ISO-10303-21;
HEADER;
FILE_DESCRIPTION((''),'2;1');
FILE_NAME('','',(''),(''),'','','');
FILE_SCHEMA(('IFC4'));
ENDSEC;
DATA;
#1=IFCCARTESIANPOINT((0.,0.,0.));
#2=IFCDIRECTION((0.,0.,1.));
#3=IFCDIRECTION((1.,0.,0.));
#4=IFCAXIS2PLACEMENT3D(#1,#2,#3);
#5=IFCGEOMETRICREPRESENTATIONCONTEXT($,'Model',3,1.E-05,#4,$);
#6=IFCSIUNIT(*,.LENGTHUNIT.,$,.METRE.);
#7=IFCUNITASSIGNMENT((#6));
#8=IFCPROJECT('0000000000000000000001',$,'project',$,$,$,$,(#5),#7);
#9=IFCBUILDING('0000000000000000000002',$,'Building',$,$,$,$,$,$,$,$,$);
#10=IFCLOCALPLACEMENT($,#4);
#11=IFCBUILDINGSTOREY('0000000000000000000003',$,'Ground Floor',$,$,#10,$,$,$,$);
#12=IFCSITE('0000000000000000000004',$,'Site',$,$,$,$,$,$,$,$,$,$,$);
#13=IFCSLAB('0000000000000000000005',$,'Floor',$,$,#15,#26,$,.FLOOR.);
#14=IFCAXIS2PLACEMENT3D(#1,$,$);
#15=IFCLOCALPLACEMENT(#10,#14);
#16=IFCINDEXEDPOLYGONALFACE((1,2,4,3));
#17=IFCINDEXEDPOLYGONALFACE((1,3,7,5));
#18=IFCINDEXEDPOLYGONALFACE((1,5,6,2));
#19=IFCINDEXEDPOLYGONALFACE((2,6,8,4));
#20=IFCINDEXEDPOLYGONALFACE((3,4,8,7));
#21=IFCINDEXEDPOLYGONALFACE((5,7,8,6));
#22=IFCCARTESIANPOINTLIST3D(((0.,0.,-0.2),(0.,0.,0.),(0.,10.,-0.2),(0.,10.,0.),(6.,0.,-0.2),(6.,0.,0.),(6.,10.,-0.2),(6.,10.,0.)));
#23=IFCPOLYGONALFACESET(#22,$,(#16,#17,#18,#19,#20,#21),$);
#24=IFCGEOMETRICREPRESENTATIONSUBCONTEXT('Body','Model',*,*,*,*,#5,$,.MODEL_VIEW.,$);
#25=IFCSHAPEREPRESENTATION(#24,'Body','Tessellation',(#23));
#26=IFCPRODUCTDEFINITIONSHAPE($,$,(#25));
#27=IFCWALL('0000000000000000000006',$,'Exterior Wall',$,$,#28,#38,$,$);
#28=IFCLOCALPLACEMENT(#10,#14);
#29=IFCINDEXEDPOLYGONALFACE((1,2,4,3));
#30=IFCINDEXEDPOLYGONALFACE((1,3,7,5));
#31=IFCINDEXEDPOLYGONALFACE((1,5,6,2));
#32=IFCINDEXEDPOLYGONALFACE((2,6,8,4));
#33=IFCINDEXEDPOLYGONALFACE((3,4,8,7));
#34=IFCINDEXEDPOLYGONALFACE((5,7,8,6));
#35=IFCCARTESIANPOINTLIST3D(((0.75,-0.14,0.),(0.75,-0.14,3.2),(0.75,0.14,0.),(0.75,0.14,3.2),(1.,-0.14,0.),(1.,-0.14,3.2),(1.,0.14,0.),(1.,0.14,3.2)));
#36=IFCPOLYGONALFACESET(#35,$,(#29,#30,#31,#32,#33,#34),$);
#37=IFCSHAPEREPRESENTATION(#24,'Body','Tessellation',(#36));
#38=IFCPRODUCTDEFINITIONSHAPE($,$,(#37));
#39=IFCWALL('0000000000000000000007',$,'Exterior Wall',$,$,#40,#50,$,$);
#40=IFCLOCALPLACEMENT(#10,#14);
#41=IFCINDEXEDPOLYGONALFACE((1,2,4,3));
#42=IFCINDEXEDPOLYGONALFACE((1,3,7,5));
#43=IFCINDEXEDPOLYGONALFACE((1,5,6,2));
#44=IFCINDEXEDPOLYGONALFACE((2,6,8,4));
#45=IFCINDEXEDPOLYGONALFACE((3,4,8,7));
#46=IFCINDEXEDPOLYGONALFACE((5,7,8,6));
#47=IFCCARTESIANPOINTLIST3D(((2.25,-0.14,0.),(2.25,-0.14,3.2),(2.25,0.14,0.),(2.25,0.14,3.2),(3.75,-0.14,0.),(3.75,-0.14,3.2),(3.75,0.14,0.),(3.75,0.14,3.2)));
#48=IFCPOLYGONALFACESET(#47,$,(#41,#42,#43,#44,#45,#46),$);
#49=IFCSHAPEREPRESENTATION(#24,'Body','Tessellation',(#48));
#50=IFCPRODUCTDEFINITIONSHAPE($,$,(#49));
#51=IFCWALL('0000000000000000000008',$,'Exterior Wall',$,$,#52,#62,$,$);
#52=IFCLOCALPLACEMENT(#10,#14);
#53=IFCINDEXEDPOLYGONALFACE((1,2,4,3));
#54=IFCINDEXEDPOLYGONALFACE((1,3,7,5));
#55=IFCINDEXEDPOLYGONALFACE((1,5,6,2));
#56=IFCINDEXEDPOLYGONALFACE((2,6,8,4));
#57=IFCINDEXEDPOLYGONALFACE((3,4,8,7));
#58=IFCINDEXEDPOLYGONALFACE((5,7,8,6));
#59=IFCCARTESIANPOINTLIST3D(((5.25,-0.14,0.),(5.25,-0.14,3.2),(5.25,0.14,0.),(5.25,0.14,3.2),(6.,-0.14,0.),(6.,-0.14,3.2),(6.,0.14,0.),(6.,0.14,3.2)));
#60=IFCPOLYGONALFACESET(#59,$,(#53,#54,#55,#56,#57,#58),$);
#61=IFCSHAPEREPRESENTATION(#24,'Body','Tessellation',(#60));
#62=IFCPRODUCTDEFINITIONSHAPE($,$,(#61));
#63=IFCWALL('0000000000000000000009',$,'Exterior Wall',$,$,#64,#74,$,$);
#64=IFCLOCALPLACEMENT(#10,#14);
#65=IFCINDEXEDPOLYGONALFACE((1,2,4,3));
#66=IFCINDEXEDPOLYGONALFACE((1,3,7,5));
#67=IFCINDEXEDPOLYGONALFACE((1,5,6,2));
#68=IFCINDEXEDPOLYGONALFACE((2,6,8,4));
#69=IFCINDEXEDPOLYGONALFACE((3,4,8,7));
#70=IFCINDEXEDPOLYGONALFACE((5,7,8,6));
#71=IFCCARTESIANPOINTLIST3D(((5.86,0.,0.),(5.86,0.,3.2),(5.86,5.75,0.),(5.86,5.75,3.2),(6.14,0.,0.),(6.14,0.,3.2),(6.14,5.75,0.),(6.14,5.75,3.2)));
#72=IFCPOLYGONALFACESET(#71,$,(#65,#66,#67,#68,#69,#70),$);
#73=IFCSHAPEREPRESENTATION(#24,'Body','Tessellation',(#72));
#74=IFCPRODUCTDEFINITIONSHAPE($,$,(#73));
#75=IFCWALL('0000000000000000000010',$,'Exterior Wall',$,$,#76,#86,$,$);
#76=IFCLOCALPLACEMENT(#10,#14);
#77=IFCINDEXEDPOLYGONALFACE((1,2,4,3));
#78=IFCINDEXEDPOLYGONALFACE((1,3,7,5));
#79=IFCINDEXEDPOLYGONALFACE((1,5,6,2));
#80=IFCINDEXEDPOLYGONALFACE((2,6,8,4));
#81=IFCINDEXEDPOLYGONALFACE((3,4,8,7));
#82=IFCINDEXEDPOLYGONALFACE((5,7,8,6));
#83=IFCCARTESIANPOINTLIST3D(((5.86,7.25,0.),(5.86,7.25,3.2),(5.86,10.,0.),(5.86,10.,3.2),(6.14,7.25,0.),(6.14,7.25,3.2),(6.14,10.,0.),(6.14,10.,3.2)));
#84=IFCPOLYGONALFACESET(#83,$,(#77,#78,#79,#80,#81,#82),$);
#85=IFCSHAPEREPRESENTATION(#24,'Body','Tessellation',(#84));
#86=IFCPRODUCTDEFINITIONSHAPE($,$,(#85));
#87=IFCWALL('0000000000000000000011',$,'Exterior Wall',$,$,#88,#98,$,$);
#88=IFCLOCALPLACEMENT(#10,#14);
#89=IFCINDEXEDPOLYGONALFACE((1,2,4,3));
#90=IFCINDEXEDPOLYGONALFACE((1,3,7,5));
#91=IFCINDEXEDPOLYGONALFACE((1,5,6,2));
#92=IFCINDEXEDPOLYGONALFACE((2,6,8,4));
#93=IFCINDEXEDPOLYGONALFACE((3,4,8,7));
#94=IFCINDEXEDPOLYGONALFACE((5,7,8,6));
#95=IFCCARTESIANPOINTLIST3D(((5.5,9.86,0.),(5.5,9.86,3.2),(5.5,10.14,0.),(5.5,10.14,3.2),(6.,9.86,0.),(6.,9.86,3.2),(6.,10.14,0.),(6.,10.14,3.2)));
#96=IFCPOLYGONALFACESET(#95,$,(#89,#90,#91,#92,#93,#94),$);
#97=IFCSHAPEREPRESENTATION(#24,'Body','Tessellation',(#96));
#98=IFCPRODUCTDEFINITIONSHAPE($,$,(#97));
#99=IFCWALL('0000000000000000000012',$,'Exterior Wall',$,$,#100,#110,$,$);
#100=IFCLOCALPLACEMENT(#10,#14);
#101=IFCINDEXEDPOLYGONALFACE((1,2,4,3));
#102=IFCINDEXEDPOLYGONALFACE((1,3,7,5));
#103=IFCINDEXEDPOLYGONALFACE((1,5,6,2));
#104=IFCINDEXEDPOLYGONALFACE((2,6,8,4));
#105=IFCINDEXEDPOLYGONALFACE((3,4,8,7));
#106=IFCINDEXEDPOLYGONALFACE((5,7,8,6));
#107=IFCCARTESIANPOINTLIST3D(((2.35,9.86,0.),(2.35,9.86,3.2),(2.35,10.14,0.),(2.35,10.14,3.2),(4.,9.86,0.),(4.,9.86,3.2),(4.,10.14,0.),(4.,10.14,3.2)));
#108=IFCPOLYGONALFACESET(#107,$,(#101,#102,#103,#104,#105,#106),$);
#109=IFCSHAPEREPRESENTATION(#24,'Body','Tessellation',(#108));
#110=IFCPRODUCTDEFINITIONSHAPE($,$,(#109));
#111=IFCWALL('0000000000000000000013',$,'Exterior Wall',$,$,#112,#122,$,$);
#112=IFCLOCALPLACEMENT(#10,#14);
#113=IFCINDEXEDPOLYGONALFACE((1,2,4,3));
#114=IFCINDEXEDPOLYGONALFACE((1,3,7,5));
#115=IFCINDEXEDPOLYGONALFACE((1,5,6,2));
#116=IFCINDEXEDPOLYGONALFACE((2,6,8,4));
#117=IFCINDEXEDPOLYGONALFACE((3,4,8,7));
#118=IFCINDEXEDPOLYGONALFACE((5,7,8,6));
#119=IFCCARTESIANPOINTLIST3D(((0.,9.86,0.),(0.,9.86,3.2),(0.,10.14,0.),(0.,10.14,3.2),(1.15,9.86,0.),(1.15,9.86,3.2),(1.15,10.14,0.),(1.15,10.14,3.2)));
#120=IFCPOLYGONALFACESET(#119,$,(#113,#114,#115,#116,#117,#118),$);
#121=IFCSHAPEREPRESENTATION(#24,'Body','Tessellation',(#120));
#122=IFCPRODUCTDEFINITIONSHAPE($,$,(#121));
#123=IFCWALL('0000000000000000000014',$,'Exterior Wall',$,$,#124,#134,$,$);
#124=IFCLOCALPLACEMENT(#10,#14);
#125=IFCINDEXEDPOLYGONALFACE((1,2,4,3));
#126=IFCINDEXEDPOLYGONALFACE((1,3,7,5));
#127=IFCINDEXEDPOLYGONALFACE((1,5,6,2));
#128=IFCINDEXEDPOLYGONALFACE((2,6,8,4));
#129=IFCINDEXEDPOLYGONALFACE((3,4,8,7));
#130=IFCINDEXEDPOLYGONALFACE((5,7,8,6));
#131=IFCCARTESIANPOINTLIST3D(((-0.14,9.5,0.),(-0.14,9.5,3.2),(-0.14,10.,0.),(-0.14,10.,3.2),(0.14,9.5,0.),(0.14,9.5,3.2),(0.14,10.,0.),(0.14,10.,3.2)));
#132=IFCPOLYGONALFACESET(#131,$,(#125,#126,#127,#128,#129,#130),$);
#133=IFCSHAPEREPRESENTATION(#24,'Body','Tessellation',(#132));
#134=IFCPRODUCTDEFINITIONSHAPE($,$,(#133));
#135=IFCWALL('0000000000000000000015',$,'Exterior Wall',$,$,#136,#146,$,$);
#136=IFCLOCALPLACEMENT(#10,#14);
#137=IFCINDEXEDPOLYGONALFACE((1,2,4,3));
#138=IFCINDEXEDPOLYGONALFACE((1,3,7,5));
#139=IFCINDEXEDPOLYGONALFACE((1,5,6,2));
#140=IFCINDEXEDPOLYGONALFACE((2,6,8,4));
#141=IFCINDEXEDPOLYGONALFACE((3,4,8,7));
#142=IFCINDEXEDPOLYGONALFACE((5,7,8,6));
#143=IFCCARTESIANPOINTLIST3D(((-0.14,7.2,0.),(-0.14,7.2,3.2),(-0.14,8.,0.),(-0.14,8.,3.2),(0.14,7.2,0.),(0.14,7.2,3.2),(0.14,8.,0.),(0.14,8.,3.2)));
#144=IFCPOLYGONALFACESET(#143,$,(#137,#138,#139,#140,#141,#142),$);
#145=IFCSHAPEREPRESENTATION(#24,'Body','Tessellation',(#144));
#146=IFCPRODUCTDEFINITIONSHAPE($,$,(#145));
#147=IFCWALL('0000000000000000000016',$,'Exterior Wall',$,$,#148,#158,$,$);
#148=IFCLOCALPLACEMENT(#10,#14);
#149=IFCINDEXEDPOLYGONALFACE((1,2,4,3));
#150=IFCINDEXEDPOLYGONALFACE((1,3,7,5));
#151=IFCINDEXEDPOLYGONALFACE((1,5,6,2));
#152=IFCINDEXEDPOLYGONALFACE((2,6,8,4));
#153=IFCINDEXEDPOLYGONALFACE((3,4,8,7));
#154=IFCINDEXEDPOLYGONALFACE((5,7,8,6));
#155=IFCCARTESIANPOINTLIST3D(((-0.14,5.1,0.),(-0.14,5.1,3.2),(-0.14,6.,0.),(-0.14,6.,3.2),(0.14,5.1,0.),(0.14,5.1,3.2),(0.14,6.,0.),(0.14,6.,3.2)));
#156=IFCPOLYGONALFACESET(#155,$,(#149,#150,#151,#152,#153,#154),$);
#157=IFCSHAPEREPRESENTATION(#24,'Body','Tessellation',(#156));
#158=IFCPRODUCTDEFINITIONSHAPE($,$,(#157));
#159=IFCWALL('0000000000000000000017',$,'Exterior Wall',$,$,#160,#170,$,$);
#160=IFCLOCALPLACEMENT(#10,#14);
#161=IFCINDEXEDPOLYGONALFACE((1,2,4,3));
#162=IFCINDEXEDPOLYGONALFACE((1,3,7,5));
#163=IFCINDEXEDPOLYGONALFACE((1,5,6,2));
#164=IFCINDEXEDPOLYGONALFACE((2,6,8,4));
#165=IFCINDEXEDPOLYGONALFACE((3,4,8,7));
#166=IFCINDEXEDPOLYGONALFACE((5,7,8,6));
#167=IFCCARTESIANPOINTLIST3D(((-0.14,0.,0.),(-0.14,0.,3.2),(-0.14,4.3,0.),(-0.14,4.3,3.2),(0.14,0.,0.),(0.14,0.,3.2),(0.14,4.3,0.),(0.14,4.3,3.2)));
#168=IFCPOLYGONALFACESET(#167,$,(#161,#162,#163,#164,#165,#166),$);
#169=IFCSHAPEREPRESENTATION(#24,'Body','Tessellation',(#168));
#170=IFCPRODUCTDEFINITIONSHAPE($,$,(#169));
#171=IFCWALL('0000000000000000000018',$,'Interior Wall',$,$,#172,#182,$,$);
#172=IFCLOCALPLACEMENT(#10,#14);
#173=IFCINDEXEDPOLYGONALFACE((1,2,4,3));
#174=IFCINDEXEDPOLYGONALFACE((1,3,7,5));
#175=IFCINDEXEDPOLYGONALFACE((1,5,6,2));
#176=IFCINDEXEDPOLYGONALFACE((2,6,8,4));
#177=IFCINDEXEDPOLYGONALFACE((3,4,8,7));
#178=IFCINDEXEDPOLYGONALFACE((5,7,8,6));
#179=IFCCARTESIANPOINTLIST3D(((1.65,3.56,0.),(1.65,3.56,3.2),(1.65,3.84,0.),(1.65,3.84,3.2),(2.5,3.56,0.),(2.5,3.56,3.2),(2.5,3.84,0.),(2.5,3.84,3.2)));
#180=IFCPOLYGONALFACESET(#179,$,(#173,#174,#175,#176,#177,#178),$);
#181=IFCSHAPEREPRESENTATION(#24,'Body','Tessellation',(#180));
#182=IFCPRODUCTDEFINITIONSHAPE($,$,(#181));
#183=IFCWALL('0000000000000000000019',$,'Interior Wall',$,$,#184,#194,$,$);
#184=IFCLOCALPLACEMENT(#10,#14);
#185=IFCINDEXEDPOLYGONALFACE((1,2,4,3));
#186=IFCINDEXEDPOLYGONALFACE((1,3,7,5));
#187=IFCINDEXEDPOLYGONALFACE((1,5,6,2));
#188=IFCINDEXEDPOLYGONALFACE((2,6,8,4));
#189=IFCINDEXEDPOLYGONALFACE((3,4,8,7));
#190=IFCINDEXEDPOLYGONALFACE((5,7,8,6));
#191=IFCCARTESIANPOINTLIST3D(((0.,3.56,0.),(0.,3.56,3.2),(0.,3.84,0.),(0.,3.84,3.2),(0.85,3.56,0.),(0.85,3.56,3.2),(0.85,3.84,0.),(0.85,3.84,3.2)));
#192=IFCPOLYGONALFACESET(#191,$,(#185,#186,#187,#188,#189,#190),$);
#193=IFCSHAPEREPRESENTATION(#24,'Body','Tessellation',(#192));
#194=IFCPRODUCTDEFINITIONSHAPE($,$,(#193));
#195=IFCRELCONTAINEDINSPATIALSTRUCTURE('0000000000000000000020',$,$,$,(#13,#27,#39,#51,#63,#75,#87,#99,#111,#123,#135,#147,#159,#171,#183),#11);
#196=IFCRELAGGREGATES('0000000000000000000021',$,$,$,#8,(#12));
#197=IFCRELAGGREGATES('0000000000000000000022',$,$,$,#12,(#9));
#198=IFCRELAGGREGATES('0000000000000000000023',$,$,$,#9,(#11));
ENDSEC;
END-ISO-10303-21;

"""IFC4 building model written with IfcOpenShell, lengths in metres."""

from ifc_helpers import new_model, si_unit, frame, origin_with_axes, place, context, subcontext, project, spatial, indexed_curve, outline, extrude, element, save


model = new_model("IFC4")

# Units and contexts
model_context = context("Model", 3, precision=1e-05, world=origin_with_axes())
body_context = subcontext(model_context, "Body", "Model", "MODEL_VIEW")
ifc_project = project(units=[si_unit("LENGTHUNIT", "METRE")], contexts=[model_context])

# Site, building, storey
site = spatial("IfcSite", under=ifc_project, Name="Site")
building = spatial("IfcBuilding", under=site, Name="Building")
storey_placement = place(None, origin_with_axes())
storey = spatial("IfcBuildingStorey", under=building, at=storey_placement, Name="Ground Floor")

# Slab
slab_placement = place(storey_placement, frame((0.0, 0.0, -0.2), z_axis=(0.0, 0.0, 1.0), x_axis=(1.0, 0.0, 0.0)))
element("IfcSlab", 1, at=slab_placement, inside=storey, Name="Floor", PredefinedType="FLOOR", context=body_context, shape_type="SweptSolid", body=[
    extrude(outline(indexed_curve([(0.0, 0.0), (6.0, 0.0), (6.0, 10.0), (0.0, 10.0)])), None, (0.0, 0.0, 1.0), 0.2),
])

# Walls
wall_1_placement = place(storey_placement, frame((1.0, 0.0, 0.0), z_axis=(0.0, 0.0, 1.0), x_axis=(-1.0, 0.0, 0.0)))
element("IfcWall", 2, at=wall_1_placement, inside=storey, Name="Exterior Wall", context=body_context, shape_type="SweptSolid", body=[
    extrude(outline(indexed_curve([(0.0, 0.0), (0.0, 0.28), (0.25, 0.28), (0.25, 0.0), (0.0, 0.0)], self_intersect=False)), frame((0.0, -0.14, 0.0), z_axis=(0.0, 0.0, 1.0), x_axis=(1.0, 0.0, 0.0)), (0.0, 0.0, 1.0), 3.2),
])
wall_2_placement = place(storey_placement, frame((2.25, 0.0, 0.0), z_axis=(0.0, 0.0, 1.0), x_axis=(1.0, 0.0, 0.0)))
element("IfcWall", 3, at=wall_2_placement, inside=storey, Name="Exterior Wall", context=body_context, shape_type="SweptSolid", body=[
    extrude(outline(indexed_curve([(0.0, 0.0), (0.0, 0.28), (1.5, 0.28), (1.5, 0.0), (0.0, 0.0)], self_intersect=False)), frame((0.0, -0.14, 0.0), z_axis=(0.0, 0.0, 1.0), x_axis=(1.0, 0.0, 0.0)), (0.0, 0.0, 1.0), 3.2),
])
wall_3_placement = place(storey_placement, frame((5.25, 0.0, 0.0), z_axis=(0.0, 0.0, 1.0), x_axis=(1.0, 0.0, 0.0)))
element("IfcWall", 4, at=wall_3_placement, inside=storey, Name="Exterior Wall", context=body_context, shape_type="SweptSolid", body=[
    extrude(outline(indexed_curve([(0.0, 0.0), (0.0, 0.28), (0.75, 0.28), (0.75, 0.0), (0.0, 0.0)], self_intersect=False)), frame((0.0, -0.14, 0.0), z_axis=(0.0, 0.0, 1.0), x_axis=(1.0, 0.0, 0.0)), (0.0, 0.0, 1.0), 3.2),
])
wall_4_placement = place(storey_placement, frame((6.0, 0.0, 0.0), z_axis=(0.0, 0.0, 1.0), x_axis=(0.0, 1.0, 0.0)))
element("IfcWall", 5, at=wall_4_placement, inside=storey, Name="Exterior Wall", context=body_context, shape_type="SweptSolid", body=[
    extrude(outline(indexed_curve([(0.0, 0.0), (0.0, 0.28), (5.75, 0.28), (5.75, 0.0), (0.0, 0.0)], self_intersect=False)), frame((0.0, -0.14, 0.0), z_axis=(0.0, 0.0, 1.0), x_axis=(1.0, 0.0, 0.0)), (0.0, 0.0, 1.0), 3.2),
])
wall_5_placement = place(storey_placement, frame((6.0, 7.25, 0.0), z_axis=(0.0, 0.0, 1.0), x_axis=(0.0, 1.0, 0.0)))
element("IfcWall", 6, at=wall_5_placement, inside=storey, Name="Exterior Wall", context=body_context, shape_type="SweptSolid", body=[
    extrude(outline(indexed_curve([(0.0, 0.0), (0.0, 0.28), (2.75, 0.28), (2.75, 0.0), (0.0, 0.0)], self_intersect=False)), frame((0.0, -0.14, 0.0), z_axis=(0.0, 0.0, 1.0), x_axis=(1.0, 0.0, 0.0)), (0.0, 0.0, 1.0), 3.2),
])
wall_6_placement = place(storey_placement, frame((6.0, 10.0, 0.0), z_axis=(0.0, 0.0, 1.0), x_axis=(-1.0, 0.0, 0.0)))
element("IfcWall", 7, at=wall_6_placement, inside=storey, Name="Exterior Wall", context=body_context, shape_type="SweptSolid", body=[
    extrude(outline(indexed_curve([(0.0, 0.0), (0.0, 0.28), (0.5, 0.28), (0.5, 0.0), (0.0, 0.0)], self_intersect=False)), frame((0.0, -0.14, 0.0), z_axis=(0.0, 0.0, 1.0), x_axis=(1.0, 0.0, 0.0)), (0.0, 0.0, 1.0), 3.2),
])
wall_7_placement = place(storey_placement, frame((4.0, 10.0, 0.0), z_axis=(0.0, 0.0, 1.0), x_axis=(-1.0, 0.0, 0.0)))
element("IfcWall", 8, at=wall_7_placement, inside=storey, Name="Exterior Wall", context=body_context, shape_type="SweptSolid", body=[
    extrude(outline(indexed_curve([(0.0, 0.0), (0.0, 0.28), (1.65, 0.28), (1.65, 0.0), (0.0, 0.0)], self_intersect=False)), frame((0.0, -0.14, 0.0), z_axis=(0.0, 0.0, 1.0), x_axis=(1.0, 0.0, 0.0)), (0.0, 0.0, 1.0), 3.2),
])
wall_8_placement = place(storey_placement, frame((1.15, 10.0, 0.0), z_axis=(0.0, 0.0, 1.0), x_axis=(-1.0, 0.0, 0.0)))
element("IfcWall", 9, at=wall_8_placement, inside=storey, Name="Exterior Wall", context=body_context, shape_type="SweptSolid", body=[
    extrude(outline(indexed_curve([(0.0, 0.0), (0.0, 0.28), (1.15, 0.28), (1.15, 0.0), (0.0, 0.0)], self_intersect=False)), frame((0.0, -0.14, 0.0), z_axis=(0.0, 0.0, 1.0), x_axis=(1.0, 0.0, 0.0)), (0.0, 0.0, 1.0), 3.2),
])
wall_9_placement = place(storey_placement, frame((0.0, 10.0, 0.0), z_axis=(0.0, 0.0, 1.0), x_axis=(0.0, -1.0, 0.0)))
element("IfcWall", 10, at=wall_9_placement, inside=storey, Name="Exterior Wall", context=body_context, shape_type="SweptSolid", body=[
    extrude(outline(indexed_curve([(0.0, 0.0), (0.0, 0.28), (0.5, 0.28), (0.5, 0.0), (0.0, 0.0)], self_intersect=False)), frame((0.0, -0.14, 0.0), z_axis=(0.0, 0.0, 1.0), x_axis=(1.0, 0.0, 0.0)), (0.0, 0.0, 1.0), 3.2),
])
wall_10_placement = place(storey_placement, frame((0.0, 8.0, 0.0), z_axis=(0.0, 0.0, 1.0), x_axis=(0.0, -1.0, 0.0)))
element("IfcWall", 11, at=wall_10_placement, inside=storey, Name="Exterior Wall", context=body_context, shape_type="SweptSolid", body=[
    extrude(outline(indexed_curve([(0.0, 0.0), (0.0, 0.28), (0.8, 0.28), (0.8, 0.0), (0.0, 0.0)], self_intersect=False)), frame((0.0, -0.14, 0.0), z_axis=(0.0, 0.0, 1.0), x_axis=(1.0, 0.0, 0.0)), (0.0, 0.0, 1.0), 3.2),
])
wall_11_placement = place(storey_placement, frame((0.0, 6.0, 0.0), z_axis=(0.0, 0.0, 1.0), x_axis=(0.0, -1.0, 0.0)))
element("IfcWall", 12, at=wall_11_placement, inside=storey, Name="Exterior Wall", context=body_context, shape_type="SweptSolid", body=[
    extrude(outline(indexed_curve([(0.0, 0.0), (0.0, 0.28), (0.9, 0.28), (0.9, 0.0), (0.0, 0.0)], self_intersect=False)), frame((0.0, -0.14, 0.0), z_axis=(0.0, 0.0, 1.0), x_axis=(1.0, 0.0, 0.0)), (0.0, 0.0, 1.0), 3.2),
])
wall_12_placement = place(storey_placement, frame((0.0, 4.3, 0.0), z_axis=(0.0, 0.0, 1.0), x_axis=(0.0, -1.0, 0.0)))
element("IfcWall", 13, at=wall_12_placement, inside=storey, Name="Exterior Wall", context=body_context, shape_type="SweptSolid", body=[
    extrude(outline(indexed_curve([(0.0, 0.0), (0.0, 0.28), (4.3, 0.28), (4.3, 0.0), (0.0, 0.0)], self_intersect=False)), frame((0.0, -0.14, 0.0), z_axis=(0.0, 0.0, 1.0), x_axis=(1.0, 0.0, 0.0)), (0.0, 0.0, 1.0), 3.2),
])
for number, where, z_axis, x_axis, name in (
    (14, (2.5, 3.7, 0.0), (0.0, 0.0, 1.0), (-1.0, 0.0, 0.0), "Interior Wall"),
    (15, (0.85, 3.7, 0.0), (0.0, 0.0, 1.0), (-1.0, 0.0, 0.0), "Interior Wall"),
):
    element("IfcWall", number, at=place(storey_placement, frame(where, z_axis=z_axis, x_axis=x_axis)), inside=storey, Name=name, context=body_context, shape_type="SweptSolid", body=[
        extrude(outline(indexed_curve([(0.0, 0.0), (0.0, 0.28), (0.85, 0.28), (0.85, 0.0), (0.0, 0.0)], self_intersect=False)), frame((0.0, -0.14, 0.0), z_axis=(0.0, 0.0, 1.0), x_axis=(1.0, 0.0, 0.0)), (0.0, 0.0, 1.0), 3.2),
    ])

save(model, "model.ifc")
